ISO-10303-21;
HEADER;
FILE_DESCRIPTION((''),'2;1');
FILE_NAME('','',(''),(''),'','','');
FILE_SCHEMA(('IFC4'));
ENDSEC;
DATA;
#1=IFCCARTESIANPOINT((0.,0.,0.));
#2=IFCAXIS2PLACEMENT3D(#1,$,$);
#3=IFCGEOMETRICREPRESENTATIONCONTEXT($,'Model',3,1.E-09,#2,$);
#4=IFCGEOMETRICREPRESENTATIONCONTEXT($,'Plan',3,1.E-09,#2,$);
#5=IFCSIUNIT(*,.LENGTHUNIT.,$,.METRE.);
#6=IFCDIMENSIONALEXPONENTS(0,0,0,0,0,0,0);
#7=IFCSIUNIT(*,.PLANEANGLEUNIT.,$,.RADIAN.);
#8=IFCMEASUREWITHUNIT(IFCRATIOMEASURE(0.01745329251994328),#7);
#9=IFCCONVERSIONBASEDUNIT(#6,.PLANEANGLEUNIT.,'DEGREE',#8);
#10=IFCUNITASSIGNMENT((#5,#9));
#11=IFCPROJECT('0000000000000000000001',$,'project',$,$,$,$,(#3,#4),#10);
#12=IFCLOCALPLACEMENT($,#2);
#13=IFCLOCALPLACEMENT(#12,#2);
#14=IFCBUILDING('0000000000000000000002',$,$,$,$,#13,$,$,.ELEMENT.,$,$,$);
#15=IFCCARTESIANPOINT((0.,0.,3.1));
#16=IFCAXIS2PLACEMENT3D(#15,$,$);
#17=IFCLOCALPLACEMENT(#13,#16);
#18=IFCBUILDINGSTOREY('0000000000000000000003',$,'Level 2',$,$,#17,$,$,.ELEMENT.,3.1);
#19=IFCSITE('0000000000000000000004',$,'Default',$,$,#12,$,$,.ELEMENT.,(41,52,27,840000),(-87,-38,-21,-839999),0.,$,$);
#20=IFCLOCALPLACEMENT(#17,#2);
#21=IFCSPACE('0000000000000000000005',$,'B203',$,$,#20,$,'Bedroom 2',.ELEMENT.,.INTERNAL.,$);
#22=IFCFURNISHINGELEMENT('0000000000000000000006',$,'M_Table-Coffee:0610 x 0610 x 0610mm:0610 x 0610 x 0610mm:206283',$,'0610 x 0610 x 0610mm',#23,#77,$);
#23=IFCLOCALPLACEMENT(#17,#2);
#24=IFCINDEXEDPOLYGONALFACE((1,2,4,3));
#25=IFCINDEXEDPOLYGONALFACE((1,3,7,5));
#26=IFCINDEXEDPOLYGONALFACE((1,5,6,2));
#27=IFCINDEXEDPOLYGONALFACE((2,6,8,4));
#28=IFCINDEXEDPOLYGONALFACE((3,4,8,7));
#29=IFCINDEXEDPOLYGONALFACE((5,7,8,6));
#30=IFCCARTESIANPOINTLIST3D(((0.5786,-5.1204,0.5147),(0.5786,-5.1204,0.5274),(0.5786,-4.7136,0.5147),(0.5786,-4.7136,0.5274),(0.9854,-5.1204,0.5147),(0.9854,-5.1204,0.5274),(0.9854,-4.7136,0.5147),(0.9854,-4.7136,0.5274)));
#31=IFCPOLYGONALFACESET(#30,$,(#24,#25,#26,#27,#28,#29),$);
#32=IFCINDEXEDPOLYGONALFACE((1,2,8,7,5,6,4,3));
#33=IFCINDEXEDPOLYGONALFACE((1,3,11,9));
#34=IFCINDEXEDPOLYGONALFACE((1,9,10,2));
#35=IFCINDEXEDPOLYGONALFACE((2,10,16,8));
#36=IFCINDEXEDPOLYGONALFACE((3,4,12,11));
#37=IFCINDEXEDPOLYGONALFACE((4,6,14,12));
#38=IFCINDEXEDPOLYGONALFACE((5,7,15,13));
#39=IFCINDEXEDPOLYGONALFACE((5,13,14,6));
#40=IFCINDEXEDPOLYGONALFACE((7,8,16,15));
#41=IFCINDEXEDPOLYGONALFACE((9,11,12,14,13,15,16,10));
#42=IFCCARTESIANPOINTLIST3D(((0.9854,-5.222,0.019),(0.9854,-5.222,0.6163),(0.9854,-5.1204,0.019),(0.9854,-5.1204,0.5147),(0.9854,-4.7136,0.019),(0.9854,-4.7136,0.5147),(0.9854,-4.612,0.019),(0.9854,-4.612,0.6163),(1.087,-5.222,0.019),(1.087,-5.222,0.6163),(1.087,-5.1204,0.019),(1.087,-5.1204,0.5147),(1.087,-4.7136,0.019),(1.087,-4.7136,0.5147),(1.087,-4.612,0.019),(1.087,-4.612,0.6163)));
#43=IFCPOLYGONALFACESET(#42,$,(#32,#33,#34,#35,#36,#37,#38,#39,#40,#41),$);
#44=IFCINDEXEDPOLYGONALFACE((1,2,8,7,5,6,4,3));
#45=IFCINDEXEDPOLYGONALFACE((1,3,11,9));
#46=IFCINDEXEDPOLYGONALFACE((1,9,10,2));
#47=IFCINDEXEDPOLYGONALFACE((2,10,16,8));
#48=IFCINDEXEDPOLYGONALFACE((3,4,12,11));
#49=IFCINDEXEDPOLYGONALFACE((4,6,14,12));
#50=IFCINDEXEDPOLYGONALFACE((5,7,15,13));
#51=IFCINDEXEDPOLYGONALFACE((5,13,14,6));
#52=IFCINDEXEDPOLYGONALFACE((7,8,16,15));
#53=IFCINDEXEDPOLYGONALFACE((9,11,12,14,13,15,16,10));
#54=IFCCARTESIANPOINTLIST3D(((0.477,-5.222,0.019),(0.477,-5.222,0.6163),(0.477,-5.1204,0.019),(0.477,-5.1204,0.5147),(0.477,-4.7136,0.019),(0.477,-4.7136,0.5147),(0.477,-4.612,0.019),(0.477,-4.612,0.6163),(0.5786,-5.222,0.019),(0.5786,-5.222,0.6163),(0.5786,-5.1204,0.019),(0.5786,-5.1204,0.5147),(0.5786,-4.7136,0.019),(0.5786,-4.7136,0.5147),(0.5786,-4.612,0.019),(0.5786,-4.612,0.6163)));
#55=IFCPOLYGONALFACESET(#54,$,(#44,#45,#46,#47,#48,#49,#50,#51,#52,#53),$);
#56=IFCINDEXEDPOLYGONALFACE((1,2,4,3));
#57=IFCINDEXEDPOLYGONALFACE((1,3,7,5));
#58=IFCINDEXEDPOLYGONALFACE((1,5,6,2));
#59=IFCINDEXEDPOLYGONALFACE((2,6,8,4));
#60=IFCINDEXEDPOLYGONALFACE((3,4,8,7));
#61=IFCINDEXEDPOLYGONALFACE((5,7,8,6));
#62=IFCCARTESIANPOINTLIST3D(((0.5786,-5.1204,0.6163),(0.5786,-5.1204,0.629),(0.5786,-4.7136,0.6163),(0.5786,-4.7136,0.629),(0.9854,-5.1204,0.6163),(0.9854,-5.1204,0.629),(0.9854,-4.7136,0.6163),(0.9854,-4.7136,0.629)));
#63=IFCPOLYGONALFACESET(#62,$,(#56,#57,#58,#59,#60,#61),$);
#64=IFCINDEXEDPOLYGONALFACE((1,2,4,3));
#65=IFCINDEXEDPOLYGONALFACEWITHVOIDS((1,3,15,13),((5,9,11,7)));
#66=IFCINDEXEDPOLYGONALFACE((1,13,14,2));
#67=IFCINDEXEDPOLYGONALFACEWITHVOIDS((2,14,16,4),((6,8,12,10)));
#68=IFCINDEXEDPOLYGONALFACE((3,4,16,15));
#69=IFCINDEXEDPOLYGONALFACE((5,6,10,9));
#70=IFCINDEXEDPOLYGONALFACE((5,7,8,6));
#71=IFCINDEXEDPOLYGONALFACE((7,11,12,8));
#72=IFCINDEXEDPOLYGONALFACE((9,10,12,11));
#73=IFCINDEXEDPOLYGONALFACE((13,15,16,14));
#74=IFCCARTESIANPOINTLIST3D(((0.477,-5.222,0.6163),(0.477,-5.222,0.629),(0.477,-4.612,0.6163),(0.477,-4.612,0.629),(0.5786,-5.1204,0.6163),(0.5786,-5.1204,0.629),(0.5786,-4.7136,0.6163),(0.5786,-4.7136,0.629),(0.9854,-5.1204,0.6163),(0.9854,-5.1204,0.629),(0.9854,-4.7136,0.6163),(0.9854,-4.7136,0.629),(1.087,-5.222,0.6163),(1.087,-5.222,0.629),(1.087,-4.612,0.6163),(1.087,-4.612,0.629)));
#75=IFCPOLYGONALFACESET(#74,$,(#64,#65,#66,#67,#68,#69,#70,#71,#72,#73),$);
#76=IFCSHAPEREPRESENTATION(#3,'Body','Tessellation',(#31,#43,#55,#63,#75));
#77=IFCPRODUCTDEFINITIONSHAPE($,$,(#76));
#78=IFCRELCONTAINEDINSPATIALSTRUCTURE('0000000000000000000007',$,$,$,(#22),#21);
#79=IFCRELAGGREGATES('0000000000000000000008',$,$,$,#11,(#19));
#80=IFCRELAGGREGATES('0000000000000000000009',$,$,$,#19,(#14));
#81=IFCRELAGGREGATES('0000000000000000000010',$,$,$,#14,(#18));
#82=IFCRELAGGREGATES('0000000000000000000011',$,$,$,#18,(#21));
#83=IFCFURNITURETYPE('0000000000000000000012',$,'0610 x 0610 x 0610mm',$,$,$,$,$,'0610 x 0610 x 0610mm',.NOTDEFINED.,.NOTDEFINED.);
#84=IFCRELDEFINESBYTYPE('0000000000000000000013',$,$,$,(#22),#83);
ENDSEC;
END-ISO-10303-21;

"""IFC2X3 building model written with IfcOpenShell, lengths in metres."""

from ifc_helpers import new_model, entity, si_unit, converted_unit, frame, origin, origin_2d_with_axis, place, context, project, spatial, polyline, rectangle, outline, extrude, source, transform, mapped, type_object, type_shapes, element, save


model = new_model("IFC2X3")

# Units and contexts
model_context = context("Model", 3, precision=1e-09, world=origin())
plan_context = context("Plan", 3, precision=1e-09, world=origin())
ifc_project = project(units=[si_unit("LENGTHUNIT", "METRE"), converted_unit("PLANEANGLEUNIT", "DEGREE", entity("IfcRatioMeasure", 0.01745329251994328), si_unit("PLANEANGLEUNIT", "RADIAN"), dimensions=[0, 0, 0, 0, 0, 0, 0])], contexts=[model_context, plan_context])

# Site, building, storey
site_placement = place(None, origin())
site = spatial("IfcSite", under=ifc_project, at=site_placement, Name="Default", CompositionType="ELEMENT", RefLatitude=(41, 52, 27, 840000), RefLongitude=(-87, -38, -21, -839999), RefElevation=0.0)
building_placement = place(site_placement, origin())
building = spatial("IfcBuilding", under=site, at=building_placement, CompositionType="ELEMENT")
storey_placement = place(building_placement, frame((0.0, 0.0, 3.1)))
storey = spatial("IfcBuildingStorey", under=building, at=storey_placement, Name="Level 2", CompositionType="ELEMENT", Elevation=3.1)

# Shared definitions
space_placement = place(storey_placement, origin())
space = spatial("IfcSpace", under=storey, at=space_placement, Name="B203", LongName="Bedroom 2", CompositionType="ELEMENT", InteriorOrExteriorSpace="INTERNAL")

# Furnishing element
furniture_type = type_object("IfcFurnitureType", Name="0610 x 0610 x 0610mm", ElementType="0610 x 0610 x 0610mm", AssemblyPlace="NOTDEFINED")
shared_shape_1 = source(origin(), model_context, "Body", "SweptSolid", [
    extrude(rectangle(XDim=0.4068, YDim=0.4068, at=origin_2d_with_axis()), frame((0.0183, 0.0952, 0.4957), z_axis=(0.0, 0.0, 1.0), x_axis=(-1.0, 0.0, 0.0)), (0.0, 0.0, 1.0), 0.0127),
    extrude(outline(polyline([(-0.2732, -0.305), (0.324, -0.305), (0.324, 0.305), (-0.2732, 0.305), (-0.2732, 0.2034), (0.2225, 0.2034), (0.2225, -0.2034), (-0.2732, -0.2034), (-0.2732, -0.305)])), frame((0.2217, 0.0952, 0.2732), z_axis=(1.0, 0.0, 0.0), x_axis=(0.0, 0.0, 1.0)), (0.0, 0.0, 1.0), 0.1016),
    extrude(outline(polyline([(-0.305, -0.3241), (0.305, -0.3241), (0.305, 0.2733), (0.2034, 0.2733), (0.2034, -0.2224), (-0.2034, -0.2224), (-0.2034, 0.2733), (-0.305, 0.2733), (-0.305, -0.3241)])), frame((-0.2867, 0.0952, 0.2733), z_axis=(1.0, 0.0, 0.0), x_axis=(0.0, -1.0, 0.0)), (0.0, 0.0, 1.0), 0.1016),
    extrude(rectangle(XDim=0.4068, YDim=0.4068, at=origin_2d_with_axis()), frame((0.0183, 0.0952, 0.5973), z_axis=(0.0, 0.0, 1.0), x_axis=(-1.0, 0.0, 0.0)), (0.0, 0.0, 1.0), 0.0127),
    extrude(outline(polyline([(-0.305, -0.305), (0.305, -0.305), (0.305, 0.305), (-0.305, 0.305), (-0.305, -0.305)]), holes=[polyline([(-0.2034, -0.2034), (-0.2034, 0.2034), (0.2034, 0.2034), (0.2034, -0.2034), (-0.2034, -0.2034)])]), frame((0.0183, 0.0952, 0.5973), z_axis=(0.0, 0.0, 1.0), x_axis=(-1.0, 0.0, 0.0)), (0.0, 0.0, 1.0), 0.0127),
])
type_shapes(furniture_type, [shared_shape_1])
furnishing_placement = place(space_placement, frame((0.7637, -5.0122, 0.019)))
element("IfcFurnishingElement", 1, at=furnishing_placement, inside=space, type_object=furniture_type, Name="M_Table-Coffee:0610 x 0610 x 0610mm:0610 x 0610 x 0610mm:206283", ObjectType="0610 x 0610 x 0610mm", context=model_context, shape_type="MappedRepresentation", body=[
    mapped(shared_shape_1, transform((0.0, 0.0, 0.0), scale=1.0)),
])

save(model, "model.ifc")
